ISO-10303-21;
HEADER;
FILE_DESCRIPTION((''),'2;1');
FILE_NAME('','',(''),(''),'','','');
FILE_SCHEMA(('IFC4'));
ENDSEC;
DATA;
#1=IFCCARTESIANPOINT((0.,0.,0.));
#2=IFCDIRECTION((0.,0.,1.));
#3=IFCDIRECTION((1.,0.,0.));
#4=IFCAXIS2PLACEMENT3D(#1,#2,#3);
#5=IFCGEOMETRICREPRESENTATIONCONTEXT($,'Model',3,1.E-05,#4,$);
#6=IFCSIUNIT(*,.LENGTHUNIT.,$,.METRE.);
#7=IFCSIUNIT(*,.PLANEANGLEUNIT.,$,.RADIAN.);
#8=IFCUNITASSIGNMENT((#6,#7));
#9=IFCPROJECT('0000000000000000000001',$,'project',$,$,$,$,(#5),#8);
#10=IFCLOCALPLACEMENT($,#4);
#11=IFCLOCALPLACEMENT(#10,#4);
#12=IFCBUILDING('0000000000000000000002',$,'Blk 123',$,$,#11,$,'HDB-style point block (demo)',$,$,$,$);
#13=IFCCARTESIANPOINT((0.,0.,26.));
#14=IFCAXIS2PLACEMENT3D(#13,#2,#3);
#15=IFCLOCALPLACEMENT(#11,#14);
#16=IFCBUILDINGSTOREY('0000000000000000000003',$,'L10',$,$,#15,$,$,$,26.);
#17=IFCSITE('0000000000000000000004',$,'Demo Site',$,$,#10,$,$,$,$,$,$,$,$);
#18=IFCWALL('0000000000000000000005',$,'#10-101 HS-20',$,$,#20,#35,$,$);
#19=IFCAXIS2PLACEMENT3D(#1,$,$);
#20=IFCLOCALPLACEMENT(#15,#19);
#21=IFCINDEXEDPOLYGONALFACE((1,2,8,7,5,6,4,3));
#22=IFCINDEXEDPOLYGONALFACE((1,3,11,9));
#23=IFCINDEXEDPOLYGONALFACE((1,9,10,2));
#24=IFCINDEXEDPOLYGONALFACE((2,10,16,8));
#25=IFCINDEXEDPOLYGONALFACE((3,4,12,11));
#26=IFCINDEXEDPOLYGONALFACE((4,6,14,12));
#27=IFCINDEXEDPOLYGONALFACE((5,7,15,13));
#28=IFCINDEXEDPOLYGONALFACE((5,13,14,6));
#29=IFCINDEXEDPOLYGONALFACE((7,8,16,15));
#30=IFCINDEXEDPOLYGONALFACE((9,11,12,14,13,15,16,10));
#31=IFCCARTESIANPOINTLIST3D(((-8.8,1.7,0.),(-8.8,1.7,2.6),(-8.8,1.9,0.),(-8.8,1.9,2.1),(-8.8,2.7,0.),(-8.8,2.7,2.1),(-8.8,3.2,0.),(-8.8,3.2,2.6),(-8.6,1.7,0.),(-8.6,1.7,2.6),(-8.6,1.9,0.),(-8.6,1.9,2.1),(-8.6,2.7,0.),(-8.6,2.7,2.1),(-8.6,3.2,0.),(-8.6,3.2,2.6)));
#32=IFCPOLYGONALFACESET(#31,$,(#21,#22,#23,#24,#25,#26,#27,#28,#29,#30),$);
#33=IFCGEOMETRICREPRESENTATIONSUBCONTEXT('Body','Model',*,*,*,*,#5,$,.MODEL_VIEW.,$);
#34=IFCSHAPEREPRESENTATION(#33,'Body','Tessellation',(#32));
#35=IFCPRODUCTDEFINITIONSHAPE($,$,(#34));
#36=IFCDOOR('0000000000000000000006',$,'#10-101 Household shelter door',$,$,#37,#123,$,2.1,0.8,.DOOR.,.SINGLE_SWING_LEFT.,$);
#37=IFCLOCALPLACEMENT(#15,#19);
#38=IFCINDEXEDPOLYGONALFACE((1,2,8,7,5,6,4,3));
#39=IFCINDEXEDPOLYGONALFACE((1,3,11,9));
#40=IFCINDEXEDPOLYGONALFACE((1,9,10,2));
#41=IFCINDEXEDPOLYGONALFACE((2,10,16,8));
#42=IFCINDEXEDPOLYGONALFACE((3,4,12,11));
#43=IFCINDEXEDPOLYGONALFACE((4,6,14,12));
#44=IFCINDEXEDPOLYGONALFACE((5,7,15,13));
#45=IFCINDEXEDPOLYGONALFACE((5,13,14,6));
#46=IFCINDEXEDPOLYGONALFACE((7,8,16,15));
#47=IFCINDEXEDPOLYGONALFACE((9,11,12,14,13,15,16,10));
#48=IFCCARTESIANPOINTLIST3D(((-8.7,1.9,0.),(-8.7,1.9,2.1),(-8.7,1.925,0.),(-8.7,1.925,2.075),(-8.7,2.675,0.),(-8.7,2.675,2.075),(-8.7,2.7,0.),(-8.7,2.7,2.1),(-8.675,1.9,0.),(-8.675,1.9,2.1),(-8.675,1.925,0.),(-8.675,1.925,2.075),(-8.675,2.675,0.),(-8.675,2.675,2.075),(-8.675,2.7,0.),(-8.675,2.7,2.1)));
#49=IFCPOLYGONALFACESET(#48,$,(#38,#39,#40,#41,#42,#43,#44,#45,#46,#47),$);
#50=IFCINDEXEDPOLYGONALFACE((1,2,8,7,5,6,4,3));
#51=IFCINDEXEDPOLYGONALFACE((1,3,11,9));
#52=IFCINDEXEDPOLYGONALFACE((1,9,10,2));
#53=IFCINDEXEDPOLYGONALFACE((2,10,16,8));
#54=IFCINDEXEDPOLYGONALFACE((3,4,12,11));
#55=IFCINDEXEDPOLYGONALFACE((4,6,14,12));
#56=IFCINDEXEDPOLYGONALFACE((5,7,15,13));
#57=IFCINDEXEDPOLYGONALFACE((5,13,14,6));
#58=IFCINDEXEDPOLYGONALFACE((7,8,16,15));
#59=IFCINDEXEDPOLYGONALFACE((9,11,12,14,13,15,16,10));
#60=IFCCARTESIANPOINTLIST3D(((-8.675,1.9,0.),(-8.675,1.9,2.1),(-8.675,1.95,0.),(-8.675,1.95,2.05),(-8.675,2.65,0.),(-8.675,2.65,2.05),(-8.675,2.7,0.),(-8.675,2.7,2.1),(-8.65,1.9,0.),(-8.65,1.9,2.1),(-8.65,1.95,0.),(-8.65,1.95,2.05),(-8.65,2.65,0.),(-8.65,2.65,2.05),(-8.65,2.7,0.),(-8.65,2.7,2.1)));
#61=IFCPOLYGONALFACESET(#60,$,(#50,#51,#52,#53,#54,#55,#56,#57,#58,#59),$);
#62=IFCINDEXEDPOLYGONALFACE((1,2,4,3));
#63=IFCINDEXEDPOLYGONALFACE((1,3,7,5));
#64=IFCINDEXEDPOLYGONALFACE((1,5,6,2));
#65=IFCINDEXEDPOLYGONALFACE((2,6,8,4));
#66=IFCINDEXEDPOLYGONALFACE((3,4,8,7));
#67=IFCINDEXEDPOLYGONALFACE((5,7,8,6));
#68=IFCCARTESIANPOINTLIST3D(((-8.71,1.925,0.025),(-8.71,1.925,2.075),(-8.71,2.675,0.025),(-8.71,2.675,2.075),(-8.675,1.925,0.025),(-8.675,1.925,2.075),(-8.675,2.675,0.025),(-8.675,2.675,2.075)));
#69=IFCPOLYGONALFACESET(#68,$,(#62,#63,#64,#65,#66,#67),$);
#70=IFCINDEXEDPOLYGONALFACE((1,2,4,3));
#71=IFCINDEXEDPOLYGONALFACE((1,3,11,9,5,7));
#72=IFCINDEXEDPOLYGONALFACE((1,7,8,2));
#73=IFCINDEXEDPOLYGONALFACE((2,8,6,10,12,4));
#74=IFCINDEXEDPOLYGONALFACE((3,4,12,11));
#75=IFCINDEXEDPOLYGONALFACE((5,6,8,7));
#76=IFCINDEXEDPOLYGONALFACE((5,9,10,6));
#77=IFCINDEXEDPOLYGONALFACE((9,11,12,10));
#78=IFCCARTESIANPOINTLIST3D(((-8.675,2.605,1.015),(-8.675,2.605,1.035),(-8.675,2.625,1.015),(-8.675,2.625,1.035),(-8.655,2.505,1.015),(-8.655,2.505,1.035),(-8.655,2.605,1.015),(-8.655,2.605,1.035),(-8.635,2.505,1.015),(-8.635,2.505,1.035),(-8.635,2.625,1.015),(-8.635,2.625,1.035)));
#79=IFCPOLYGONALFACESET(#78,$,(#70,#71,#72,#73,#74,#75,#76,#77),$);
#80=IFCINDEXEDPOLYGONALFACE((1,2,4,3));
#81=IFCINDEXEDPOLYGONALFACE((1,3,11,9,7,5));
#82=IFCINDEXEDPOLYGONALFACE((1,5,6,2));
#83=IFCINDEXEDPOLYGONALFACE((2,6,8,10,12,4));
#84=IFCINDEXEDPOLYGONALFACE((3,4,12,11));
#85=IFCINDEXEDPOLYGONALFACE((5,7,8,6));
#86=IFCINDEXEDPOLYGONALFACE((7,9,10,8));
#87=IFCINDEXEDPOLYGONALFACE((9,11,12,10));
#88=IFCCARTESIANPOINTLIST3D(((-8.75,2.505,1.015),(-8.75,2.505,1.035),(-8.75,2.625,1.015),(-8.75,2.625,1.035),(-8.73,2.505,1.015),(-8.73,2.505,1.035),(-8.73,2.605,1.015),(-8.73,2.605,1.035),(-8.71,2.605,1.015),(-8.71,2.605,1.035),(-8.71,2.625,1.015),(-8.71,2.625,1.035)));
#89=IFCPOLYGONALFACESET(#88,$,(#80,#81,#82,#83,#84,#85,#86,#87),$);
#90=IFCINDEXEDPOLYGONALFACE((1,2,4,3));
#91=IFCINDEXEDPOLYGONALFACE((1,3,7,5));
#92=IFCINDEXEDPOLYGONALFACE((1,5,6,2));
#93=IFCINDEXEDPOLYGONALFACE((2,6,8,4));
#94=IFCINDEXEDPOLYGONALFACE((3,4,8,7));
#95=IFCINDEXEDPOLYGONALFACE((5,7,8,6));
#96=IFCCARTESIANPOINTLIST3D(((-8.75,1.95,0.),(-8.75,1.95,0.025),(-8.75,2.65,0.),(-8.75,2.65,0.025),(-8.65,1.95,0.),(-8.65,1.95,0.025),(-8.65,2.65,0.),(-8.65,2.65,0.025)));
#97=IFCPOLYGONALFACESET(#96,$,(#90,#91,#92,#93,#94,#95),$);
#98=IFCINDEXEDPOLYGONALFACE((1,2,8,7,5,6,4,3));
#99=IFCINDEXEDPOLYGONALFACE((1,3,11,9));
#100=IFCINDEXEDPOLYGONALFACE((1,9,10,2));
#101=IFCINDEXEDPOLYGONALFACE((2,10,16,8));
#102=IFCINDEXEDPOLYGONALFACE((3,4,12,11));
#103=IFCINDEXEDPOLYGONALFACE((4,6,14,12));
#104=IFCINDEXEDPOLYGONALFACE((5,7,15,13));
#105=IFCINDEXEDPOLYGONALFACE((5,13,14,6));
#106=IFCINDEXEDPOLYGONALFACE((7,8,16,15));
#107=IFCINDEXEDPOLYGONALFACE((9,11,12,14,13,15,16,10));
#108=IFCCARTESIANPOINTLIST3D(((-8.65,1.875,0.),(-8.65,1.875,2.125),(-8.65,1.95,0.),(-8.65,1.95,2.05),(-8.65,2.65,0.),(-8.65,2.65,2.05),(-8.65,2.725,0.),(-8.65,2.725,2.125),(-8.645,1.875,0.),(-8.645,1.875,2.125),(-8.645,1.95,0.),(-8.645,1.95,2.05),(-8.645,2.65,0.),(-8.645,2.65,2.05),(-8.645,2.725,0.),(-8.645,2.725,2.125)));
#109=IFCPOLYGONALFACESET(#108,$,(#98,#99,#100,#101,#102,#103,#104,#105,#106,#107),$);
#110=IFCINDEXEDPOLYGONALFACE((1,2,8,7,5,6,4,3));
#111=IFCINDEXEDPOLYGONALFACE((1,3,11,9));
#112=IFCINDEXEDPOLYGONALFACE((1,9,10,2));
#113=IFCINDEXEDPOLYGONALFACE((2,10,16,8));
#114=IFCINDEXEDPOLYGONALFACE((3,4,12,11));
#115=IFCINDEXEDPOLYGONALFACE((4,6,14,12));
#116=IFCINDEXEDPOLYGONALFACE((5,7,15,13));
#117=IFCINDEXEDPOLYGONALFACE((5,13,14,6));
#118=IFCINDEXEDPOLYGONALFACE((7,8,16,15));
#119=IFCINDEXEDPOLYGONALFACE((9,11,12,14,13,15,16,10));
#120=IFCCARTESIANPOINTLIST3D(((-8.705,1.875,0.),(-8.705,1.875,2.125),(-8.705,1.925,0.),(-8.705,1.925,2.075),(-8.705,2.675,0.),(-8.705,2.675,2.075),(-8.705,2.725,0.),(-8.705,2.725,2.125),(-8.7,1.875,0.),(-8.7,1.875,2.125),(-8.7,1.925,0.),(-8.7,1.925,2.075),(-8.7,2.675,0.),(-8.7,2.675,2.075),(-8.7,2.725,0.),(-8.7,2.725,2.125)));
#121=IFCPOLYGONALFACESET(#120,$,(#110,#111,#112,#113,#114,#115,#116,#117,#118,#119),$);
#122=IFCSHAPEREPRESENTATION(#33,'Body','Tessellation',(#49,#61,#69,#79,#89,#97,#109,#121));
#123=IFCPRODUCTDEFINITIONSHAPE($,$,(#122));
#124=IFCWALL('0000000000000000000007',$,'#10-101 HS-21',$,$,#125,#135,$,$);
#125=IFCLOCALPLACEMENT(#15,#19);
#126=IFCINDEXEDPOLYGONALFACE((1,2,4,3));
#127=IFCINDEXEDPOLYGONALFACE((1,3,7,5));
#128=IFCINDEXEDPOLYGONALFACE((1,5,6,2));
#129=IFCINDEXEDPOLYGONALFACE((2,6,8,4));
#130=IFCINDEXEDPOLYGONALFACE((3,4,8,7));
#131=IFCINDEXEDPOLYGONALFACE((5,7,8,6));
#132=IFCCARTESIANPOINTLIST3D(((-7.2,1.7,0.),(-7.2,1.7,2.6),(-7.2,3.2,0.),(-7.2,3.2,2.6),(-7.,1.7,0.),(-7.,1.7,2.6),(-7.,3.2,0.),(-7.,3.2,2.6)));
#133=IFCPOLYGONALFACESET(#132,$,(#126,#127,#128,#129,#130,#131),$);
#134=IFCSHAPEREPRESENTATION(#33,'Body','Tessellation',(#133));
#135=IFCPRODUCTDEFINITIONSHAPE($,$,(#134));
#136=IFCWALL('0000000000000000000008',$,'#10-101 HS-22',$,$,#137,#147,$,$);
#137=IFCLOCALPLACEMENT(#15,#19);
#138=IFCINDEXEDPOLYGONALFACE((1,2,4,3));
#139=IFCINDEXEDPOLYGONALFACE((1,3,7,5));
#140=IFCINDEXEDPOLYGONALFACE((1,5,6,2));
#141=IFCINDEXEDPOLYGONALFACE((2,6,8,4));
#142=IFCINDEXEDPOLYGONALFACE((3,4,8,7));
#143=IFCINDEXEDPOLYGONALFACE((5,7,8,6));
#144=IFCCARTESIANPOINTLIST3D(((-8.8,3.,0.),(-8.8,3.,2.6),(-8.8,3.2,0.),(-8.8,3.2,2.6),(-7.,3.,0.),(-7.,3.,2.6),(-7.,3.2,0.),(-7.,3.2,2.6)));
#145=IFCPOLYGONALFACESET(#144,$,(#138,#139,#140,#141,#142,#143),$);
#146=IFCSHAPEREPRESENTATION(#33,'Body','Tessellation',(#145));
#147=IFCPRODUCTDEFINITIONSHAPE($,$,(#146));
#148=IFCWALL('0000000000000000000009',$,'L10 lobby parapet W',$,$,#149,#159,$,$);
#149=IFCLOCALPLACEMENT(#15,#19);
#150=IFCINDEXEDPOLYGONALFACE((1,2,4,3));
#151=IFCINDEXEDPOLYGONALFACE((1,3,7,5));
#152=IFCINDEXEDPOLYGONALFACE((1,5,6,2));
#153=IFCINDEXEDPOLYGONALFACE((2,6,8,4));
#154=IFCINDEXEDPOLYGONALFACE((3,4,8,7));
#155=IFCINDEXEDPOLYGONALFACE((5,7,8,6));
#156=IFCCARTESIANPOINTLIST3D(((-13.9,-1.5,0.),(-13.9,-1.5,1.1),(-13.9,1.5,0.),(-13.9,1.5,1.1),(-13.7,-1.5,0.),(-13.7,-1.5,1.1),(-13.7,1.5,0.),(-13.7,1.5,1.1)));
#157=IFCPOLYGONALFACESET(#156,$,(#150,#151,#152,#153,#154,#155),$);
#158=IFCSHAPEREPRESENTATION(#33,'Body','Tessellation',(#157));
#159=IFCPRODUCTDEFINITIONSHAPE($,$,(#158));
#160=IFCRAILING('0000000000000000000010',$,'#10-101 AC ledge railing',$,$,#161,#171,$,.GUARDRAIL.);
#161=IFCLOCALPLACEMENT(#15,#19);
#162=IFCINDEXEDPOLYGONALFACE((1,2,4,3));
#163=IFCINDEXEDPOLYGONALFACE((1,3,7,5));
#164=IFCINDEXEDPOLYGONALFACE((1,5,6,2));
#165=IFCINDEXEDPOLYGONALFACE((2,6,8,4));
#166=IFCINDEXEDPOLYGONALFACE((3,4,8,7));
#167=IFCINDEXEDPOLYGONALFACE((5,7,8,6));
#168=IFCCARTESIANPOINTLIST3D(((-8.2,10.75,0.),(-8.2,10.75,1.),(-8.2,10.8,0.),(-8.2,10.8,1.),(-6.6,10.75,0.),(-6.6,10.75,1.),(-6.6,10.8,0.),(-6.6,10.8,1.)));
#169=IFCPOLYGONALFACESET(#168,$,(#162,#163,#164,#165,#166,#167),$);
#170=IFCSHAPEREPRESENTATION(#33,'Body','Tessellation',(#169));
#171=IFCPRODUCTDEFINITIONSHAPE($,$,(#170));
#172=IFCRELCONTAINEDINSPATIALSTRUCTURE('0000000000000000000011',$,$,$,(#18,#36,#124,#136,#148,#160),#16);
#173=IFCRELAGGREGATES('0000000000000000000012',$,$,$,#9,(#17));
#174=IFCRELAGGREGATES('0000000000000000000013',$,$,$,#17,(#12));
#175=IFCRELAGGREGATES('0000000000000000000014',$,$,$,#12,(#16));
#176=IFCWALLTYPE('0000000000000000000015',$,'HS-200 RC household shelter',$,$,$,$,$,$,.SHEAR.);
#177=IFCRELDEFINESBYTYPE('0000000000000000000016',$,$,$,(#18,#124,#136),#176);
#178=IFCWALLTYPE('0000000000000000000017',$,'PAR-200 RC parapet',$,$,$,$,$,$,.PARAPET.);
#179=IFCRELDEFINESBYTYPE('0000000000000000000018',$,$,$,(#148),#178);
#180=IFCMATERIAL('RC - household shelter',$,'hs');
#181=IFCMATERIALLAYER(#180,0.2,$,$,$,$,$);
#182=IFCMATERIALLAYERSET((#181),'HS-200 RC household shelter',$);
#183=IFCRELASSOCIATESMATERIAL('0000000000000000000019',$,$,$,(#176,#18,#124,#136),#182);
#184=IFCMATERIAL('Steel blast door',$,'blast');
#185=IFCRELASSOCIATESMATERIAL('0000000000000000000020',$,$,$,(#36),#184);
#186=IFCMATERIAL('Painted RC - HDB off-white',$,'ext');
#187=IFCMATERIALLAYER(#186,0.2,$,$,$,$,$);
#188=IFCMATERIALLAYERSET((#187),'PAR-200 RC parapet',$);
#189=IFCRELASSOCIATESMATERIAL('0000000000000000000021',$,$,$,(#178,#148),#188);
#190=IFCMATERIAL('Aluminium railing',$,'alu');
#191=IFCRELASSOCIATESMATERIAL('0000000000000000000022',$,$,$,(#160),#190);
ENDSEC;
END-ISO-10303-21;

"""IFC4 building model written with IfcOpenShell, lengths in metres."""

from ifc_helpers import new_model, si_unit, frame, origin, origin_with_axes, place, context, subcontext, project, spatial, polyline, line, indexed_curve, outline, extrude, material, layer, layer_set, layer_usage, type_object, element, fill, save


model = new_model("IFC4")

# Units and contexts
model_context = context("Model", 3, precision=1e-05, world=origin_with_axes())
body_context = subcontext(model_context, "Body", "Model", "MODEL_VIEW")
ifc_project = project(units=[si_unit("LENGTHUNIT", "METRE"), si_unit("PLANEANGLEUNIT", "RADIAN")], contexts=[model_context])

# Site, building, storey
site_placement = place(None, origin_with_axes())
site = spatial("IfcSite", under=ifc_project, at=site_placement, Name="Demo Site")
building_placement = place(site_placement, origin_with_axes())
building = spatial("IfcBuilding", under=site, at=building_placement, Name="Blk 123", LongName="HDB-style point block (demo)")
storey_placement = place(building_placement, frame((0.0, 0.0, 26.0), z_axis=(0.0, 0.0, 1.0), x_axis=(1.0, 0.0, 0.0)))
storey = spatial("IfcBuildingStorey", under=building, at=storey_placement, Name="L10", Elevation=26.0)

# Shared definitions
ifc_material_1 = material(Name="Painted RC - HDB off-white", Category="ext")

# Wall, opening, door
ifc_material_2 = material(Name="RC - household shelter", Category="hs")
ifc_layer_1 = layer(ifc_material_2, 0.2)
ifc_layer_set_1 = layer_set([ifc_layer_1], Name="HS-200 RC household shelter")
ifc_layer_usage_1 = layer_usage(ifc_layer_set_1, "AXIS2", "POSITIVE", -0.1)
wall_type_1 = type_object("IfcWallType", Name="HS-200 RC household shelter", PredefinedType="SHEAR", material=ifc_layer_set_1)
wall_1_placement = place(storey_placement, frame((-8.7, 1.7, 0.0), z_axis=(0.0, 0.0, 1.0), x_axis=(0.0, 1.0, 0.0)))
wall_1 = element("IfcWall", 1, at=wall_1_placement, inside=storey, type_object=wall_type_1, material=ifc_layer_usage_1, Name="#10-101 HS-20", context=body_context, shape_type="SweptSolid", body=[
    extrude(outline(indexed_curve([(0.0, 0.0), (0.0, 0.2), (1.5, 0.2), (1.5, 0.0), (0.0, 0.0)], self_intersect=False)), frame((0.0, -0.1, 0.0), z_axis=(0.0, 0.0, 1.0), x_axis=(1.0, 0.0, 0.0)), (0.0, 0.0, 1.0), 2.6),
])
opening_1_placement = place(wall_1_placement, frame((0.2, -0.2, 0.0), z_axis=(0.0, 0.0, 1.0), x_axis=(1.0, 0.0, 0.0)))
opening_1 = element("IfcOpeningElement", 2, at=opening_1_placement, cuts=wall_1, context=body_context, shape_type="SweptSolid", body=[
    extrude(outline(indexed_curve([(0.0, 0.0), (0.0, 0.4), (0.8, 0.4), (0.8, 0.0), (0.0, 0.0)], self_intersect=False)), origin_with_axes(), (0.0, 0.0, 1.0), 2.1),
])
ifc_material_3 = material(Name="Steel blast door", Category="blast")
door_1_placement = place(opening_1_placement, frame((0.0, 0.15, 0.0), z_axis=(0.0, 0.0, 1.0), x_axis=(1.0, 0.0, 0.0)))
door_1 = element("IfcDoor", 3, at=door_1_placement, inside=storey, material=ifc_material_3, Name="#10-101 Household shelter door", OperationType="SINGLE_SWING_LEFT", OverallHeight=2.1, OverallWidth=0.8, PredefinedType="DOOR", context=body_context, shape_type="SweptSolid", body=[
    extrude(outline(indexed_curve([(0.0, 0.0), (0.0, 2.1), (0.8, 2.1), (0.8, 0.0), (0.775, 0.0), (0.775, 2.075), (0.025, 2.075), (0.025, 0.0)], segments=[line(1, 2, 3, 4, 5, 6, 7, 8, 1)])), frame((0.0, 0.025, 0.0), z_axis=(0.0, -1.0, 0.0), x_axis=(1.0, 0.0, 0.0)), (0.0, 0.0, -1.0), 0.025),
    extrude(outline(indexed_curve([(0.0, 0.0), (0.0, 2.1), (0.8, 2.1), (0.8, 0.0), (0.75, 0.0), (0.75, 2.05), (0.05, 2.05), (0.05, 0.0)], segments=[line(1, 2, 3, 4, 5, 6, 7, 8, 1)])), frame((0.0, 0.0, 0.0), z_axis=(0.0, -1.0, 0.0), x_axis=(1.0, 0.0, 0.0)), (0.0, 0.0, -1.0), 0.025),
    extrude(outline(indexed_curve([(0.0, 0.0), (0.75, 0.0), (0.75, 0.035), (0.0, 0.035)], segments=[line(1, 2, 3, 4, 1)])), frame((0.025, 0.025, 0.025), z_axis=(0.0, 0.0, 1.0), x_axis=(1.0, 0.0, 0.0)), (0.0, 0.0, 1.0), 2.05),
    extrude(outline(indexed_curve([(0.0, 0.0), (0.0, -0.04), (-0.12, -0.04), (-0.12, -0.02), (-0.02, -0.02), (-0.02, 0.0)], segments=[line(1, 2, 3, 4, 5, 6, 1)])), frame((0.725, 0.025, 1.015), z_axis=(0.0, 0.0, 1.0), x_axis=(1.0, 0.0, 0.0)), (0.0, 0.0, 1.0), 0.02),
    extrude(outline(indexed_curve([(0.0, 0.0), (0.0, 0.04), (-0.12, 0.04), (-0.12, 0.02), (-0.02, 0.02), (-0.02, 0.0)], segments=[line(1, 2, 3, 4, 5, 6, 1)])), frame((0.725, 0.06, 1.015), z_axis=(0.0, 0.0, 1.0), x_axis=(1.0, 0.0, 0.0)), (0.0, 0.0, 1.0), 0.02),
    extrude(outline(indexed_curve([(0.0, 0.0), (0.7, 0.0), (0.7, 0.1), (0.0, 0.1)], segments=[line(1, 2, 3, 4, 1)])), frame((0.05, 0.0, 0.0), z_axis=(0.0, 0.0, 1.0), x_axis=(1.0, 0.0, 0.0)), (0.0, 0.0, 1.0), 0.025),
    extrude(outline(indexed_curve([(0.0, 0.0), (0.0, 2.125), (0.85, 2.125), (0.85, 0.0), (0.775, 0.0), (0.775, 2.05), (0.075, 2.05), (0.075, 0.0)], segments=[line(1, 2, 3, 4, 5, 6, 7, 8, 1)])), frame((-0.025, -0.005, 0.0), z_axis=(0.0, -1.0, 0.0), x_axis=(1.0, 0.0, 0.0)), (0.0, 0.0, -1.0), 0.005),
    extrude(outline(indexed_curve([(0.0, 0.0), (0.0, 2.125), (0.85, 2.125), (0.85, 0.0), (0.8, 0.0), (0.8, 2.075), (0.05, 2.075), (0.05, 0.0)], segments=[line(1, 2, 3, 4, 5, 6, 7, 8, 1)])), frame((-0.025, 0.05, 0.0), z_axis=(0.0, -1.0, 0.0), x_axis=(1.0, 0.0, 0.0)), (0.0, 0.0, -1.0), 0.005),
])
fill(opening_1, door_1)

# Walls
wall_2_placement = place(storey_placement, frame((-7.1, 1.7, 0.0), z_axis=(0.0, 0.0, 1.0), x_axis=(0.0, 1.0, 0.0)))
element("IfcWall", 4, at=wall_2_placement, inside=storey, type_object=wall_type_1, material=ifc_layer_usage_1, Name="#10-101 HS-21", context=body_context, shape_type="SweptSolid", body=[
    extrude(outline(indexed_curve([(0.0, 0.0), (0.0, 0.2), (1.5, 0.2), (1.5, 0.0), (0.0, 0.0)], self_intersect=False)), frame((0.0, -0.1, 0.0), z_axis=(0.0, 0.0, 1.0), x_axis=(1.0, 0.0, 0.0)), (0.0, 0.0, 1.0), 2.6),
])
wall_3_placement = place(storey_placement, frame((-7.0, 3.1, 0.0), z_axis=(0.0, 0.0, 1.0), x_axis=(-1.0, 0.0, 0.0)))
element("IfcWall", 5, at=wall_3_placement, inside=storey, type_object=wall_type_1, material=ifc_layer_usage_1, Name="#10-101 HS-22", context=body_context, shape_type="SweptSolid", body=[
    extrude(outline(indexed_curve([(0.0, 0.0), (0.0, 0.2), (1.8, 0.2), (1.8, 0.0), (0.0, 0.0)], self_intersect=False)), frame((0.0, -0.1, 0.0), z_axis=(0.0, 0.0, 1.0), x_axis=(1.0, 0.0, 0.0)), (0.0, 0.0, 1.0), 2.6),
])
ifc_layer_2 = layer(ifc_material_1, 0.2)
ifc_layer_set_2 = layer_set([ifc_layer_2], Name="PAR-200 RC parapet")
ifc_layer_usage_2 = layer_usage(ifc_layer_set_2, "AXIS2", "POSITIVE", 0.0)
wall_type_2 = type_object("IfcWallType", Name="PAR-200 RC parapet", PredefinedType="PARAPET", material=ifc_layer_set_2)
wall_4_placement = place(storey_placement, frame((-13.9, 1.5, 0.0), z_axis=(0.0, 0.0, 1.0), x_axis=(0.0, -1.0, 0.0)))
element("IfcWall", 6, at=wall_4_placement, inside=storey, type_object=wall_type_2, material=ifc_layer_usage_2, Name="L10 lobby parapet W", context=body_context, shape_type="SweptSolid", body=[
    extrude(outline(indexed_curve([(0.0, 0.0), (0.0, 0.2), (3.0, 0.2), (3.0, 0.0), (0.0, 0.0)], self_intersect=False)), origin_with_axes(), (0.0, 0.0, 1.0), 1.1),
])

# Railing
ifc_material_4 = material(Name="Aluminium railing", Category="alu")
railing_placement = place(storey_placement, frame((-7.4, 10.775, 0.0), z_axis=(0.0, 0.0, 1.0), x_axis=(1.0, 0.0, 0.0)))
element("IfcRailing", 7, at=railing_placement, inside=storey, material=ifc_material_4, Name="#10-101 AC ledge railing", PredefinedType="GUARDRAIL", context=body_context, shape_type="SweptSolid", body=[
    extrude(outline(polyline([(-0.8, -0.025), (0.8, -0.025), (0.8, 0.025), (-0.8, 0.025), (-0.8, -0.025)])), origin(), (0.0, 0.0, 1.0), 1.0),
])

save(model, "model.ifc")
